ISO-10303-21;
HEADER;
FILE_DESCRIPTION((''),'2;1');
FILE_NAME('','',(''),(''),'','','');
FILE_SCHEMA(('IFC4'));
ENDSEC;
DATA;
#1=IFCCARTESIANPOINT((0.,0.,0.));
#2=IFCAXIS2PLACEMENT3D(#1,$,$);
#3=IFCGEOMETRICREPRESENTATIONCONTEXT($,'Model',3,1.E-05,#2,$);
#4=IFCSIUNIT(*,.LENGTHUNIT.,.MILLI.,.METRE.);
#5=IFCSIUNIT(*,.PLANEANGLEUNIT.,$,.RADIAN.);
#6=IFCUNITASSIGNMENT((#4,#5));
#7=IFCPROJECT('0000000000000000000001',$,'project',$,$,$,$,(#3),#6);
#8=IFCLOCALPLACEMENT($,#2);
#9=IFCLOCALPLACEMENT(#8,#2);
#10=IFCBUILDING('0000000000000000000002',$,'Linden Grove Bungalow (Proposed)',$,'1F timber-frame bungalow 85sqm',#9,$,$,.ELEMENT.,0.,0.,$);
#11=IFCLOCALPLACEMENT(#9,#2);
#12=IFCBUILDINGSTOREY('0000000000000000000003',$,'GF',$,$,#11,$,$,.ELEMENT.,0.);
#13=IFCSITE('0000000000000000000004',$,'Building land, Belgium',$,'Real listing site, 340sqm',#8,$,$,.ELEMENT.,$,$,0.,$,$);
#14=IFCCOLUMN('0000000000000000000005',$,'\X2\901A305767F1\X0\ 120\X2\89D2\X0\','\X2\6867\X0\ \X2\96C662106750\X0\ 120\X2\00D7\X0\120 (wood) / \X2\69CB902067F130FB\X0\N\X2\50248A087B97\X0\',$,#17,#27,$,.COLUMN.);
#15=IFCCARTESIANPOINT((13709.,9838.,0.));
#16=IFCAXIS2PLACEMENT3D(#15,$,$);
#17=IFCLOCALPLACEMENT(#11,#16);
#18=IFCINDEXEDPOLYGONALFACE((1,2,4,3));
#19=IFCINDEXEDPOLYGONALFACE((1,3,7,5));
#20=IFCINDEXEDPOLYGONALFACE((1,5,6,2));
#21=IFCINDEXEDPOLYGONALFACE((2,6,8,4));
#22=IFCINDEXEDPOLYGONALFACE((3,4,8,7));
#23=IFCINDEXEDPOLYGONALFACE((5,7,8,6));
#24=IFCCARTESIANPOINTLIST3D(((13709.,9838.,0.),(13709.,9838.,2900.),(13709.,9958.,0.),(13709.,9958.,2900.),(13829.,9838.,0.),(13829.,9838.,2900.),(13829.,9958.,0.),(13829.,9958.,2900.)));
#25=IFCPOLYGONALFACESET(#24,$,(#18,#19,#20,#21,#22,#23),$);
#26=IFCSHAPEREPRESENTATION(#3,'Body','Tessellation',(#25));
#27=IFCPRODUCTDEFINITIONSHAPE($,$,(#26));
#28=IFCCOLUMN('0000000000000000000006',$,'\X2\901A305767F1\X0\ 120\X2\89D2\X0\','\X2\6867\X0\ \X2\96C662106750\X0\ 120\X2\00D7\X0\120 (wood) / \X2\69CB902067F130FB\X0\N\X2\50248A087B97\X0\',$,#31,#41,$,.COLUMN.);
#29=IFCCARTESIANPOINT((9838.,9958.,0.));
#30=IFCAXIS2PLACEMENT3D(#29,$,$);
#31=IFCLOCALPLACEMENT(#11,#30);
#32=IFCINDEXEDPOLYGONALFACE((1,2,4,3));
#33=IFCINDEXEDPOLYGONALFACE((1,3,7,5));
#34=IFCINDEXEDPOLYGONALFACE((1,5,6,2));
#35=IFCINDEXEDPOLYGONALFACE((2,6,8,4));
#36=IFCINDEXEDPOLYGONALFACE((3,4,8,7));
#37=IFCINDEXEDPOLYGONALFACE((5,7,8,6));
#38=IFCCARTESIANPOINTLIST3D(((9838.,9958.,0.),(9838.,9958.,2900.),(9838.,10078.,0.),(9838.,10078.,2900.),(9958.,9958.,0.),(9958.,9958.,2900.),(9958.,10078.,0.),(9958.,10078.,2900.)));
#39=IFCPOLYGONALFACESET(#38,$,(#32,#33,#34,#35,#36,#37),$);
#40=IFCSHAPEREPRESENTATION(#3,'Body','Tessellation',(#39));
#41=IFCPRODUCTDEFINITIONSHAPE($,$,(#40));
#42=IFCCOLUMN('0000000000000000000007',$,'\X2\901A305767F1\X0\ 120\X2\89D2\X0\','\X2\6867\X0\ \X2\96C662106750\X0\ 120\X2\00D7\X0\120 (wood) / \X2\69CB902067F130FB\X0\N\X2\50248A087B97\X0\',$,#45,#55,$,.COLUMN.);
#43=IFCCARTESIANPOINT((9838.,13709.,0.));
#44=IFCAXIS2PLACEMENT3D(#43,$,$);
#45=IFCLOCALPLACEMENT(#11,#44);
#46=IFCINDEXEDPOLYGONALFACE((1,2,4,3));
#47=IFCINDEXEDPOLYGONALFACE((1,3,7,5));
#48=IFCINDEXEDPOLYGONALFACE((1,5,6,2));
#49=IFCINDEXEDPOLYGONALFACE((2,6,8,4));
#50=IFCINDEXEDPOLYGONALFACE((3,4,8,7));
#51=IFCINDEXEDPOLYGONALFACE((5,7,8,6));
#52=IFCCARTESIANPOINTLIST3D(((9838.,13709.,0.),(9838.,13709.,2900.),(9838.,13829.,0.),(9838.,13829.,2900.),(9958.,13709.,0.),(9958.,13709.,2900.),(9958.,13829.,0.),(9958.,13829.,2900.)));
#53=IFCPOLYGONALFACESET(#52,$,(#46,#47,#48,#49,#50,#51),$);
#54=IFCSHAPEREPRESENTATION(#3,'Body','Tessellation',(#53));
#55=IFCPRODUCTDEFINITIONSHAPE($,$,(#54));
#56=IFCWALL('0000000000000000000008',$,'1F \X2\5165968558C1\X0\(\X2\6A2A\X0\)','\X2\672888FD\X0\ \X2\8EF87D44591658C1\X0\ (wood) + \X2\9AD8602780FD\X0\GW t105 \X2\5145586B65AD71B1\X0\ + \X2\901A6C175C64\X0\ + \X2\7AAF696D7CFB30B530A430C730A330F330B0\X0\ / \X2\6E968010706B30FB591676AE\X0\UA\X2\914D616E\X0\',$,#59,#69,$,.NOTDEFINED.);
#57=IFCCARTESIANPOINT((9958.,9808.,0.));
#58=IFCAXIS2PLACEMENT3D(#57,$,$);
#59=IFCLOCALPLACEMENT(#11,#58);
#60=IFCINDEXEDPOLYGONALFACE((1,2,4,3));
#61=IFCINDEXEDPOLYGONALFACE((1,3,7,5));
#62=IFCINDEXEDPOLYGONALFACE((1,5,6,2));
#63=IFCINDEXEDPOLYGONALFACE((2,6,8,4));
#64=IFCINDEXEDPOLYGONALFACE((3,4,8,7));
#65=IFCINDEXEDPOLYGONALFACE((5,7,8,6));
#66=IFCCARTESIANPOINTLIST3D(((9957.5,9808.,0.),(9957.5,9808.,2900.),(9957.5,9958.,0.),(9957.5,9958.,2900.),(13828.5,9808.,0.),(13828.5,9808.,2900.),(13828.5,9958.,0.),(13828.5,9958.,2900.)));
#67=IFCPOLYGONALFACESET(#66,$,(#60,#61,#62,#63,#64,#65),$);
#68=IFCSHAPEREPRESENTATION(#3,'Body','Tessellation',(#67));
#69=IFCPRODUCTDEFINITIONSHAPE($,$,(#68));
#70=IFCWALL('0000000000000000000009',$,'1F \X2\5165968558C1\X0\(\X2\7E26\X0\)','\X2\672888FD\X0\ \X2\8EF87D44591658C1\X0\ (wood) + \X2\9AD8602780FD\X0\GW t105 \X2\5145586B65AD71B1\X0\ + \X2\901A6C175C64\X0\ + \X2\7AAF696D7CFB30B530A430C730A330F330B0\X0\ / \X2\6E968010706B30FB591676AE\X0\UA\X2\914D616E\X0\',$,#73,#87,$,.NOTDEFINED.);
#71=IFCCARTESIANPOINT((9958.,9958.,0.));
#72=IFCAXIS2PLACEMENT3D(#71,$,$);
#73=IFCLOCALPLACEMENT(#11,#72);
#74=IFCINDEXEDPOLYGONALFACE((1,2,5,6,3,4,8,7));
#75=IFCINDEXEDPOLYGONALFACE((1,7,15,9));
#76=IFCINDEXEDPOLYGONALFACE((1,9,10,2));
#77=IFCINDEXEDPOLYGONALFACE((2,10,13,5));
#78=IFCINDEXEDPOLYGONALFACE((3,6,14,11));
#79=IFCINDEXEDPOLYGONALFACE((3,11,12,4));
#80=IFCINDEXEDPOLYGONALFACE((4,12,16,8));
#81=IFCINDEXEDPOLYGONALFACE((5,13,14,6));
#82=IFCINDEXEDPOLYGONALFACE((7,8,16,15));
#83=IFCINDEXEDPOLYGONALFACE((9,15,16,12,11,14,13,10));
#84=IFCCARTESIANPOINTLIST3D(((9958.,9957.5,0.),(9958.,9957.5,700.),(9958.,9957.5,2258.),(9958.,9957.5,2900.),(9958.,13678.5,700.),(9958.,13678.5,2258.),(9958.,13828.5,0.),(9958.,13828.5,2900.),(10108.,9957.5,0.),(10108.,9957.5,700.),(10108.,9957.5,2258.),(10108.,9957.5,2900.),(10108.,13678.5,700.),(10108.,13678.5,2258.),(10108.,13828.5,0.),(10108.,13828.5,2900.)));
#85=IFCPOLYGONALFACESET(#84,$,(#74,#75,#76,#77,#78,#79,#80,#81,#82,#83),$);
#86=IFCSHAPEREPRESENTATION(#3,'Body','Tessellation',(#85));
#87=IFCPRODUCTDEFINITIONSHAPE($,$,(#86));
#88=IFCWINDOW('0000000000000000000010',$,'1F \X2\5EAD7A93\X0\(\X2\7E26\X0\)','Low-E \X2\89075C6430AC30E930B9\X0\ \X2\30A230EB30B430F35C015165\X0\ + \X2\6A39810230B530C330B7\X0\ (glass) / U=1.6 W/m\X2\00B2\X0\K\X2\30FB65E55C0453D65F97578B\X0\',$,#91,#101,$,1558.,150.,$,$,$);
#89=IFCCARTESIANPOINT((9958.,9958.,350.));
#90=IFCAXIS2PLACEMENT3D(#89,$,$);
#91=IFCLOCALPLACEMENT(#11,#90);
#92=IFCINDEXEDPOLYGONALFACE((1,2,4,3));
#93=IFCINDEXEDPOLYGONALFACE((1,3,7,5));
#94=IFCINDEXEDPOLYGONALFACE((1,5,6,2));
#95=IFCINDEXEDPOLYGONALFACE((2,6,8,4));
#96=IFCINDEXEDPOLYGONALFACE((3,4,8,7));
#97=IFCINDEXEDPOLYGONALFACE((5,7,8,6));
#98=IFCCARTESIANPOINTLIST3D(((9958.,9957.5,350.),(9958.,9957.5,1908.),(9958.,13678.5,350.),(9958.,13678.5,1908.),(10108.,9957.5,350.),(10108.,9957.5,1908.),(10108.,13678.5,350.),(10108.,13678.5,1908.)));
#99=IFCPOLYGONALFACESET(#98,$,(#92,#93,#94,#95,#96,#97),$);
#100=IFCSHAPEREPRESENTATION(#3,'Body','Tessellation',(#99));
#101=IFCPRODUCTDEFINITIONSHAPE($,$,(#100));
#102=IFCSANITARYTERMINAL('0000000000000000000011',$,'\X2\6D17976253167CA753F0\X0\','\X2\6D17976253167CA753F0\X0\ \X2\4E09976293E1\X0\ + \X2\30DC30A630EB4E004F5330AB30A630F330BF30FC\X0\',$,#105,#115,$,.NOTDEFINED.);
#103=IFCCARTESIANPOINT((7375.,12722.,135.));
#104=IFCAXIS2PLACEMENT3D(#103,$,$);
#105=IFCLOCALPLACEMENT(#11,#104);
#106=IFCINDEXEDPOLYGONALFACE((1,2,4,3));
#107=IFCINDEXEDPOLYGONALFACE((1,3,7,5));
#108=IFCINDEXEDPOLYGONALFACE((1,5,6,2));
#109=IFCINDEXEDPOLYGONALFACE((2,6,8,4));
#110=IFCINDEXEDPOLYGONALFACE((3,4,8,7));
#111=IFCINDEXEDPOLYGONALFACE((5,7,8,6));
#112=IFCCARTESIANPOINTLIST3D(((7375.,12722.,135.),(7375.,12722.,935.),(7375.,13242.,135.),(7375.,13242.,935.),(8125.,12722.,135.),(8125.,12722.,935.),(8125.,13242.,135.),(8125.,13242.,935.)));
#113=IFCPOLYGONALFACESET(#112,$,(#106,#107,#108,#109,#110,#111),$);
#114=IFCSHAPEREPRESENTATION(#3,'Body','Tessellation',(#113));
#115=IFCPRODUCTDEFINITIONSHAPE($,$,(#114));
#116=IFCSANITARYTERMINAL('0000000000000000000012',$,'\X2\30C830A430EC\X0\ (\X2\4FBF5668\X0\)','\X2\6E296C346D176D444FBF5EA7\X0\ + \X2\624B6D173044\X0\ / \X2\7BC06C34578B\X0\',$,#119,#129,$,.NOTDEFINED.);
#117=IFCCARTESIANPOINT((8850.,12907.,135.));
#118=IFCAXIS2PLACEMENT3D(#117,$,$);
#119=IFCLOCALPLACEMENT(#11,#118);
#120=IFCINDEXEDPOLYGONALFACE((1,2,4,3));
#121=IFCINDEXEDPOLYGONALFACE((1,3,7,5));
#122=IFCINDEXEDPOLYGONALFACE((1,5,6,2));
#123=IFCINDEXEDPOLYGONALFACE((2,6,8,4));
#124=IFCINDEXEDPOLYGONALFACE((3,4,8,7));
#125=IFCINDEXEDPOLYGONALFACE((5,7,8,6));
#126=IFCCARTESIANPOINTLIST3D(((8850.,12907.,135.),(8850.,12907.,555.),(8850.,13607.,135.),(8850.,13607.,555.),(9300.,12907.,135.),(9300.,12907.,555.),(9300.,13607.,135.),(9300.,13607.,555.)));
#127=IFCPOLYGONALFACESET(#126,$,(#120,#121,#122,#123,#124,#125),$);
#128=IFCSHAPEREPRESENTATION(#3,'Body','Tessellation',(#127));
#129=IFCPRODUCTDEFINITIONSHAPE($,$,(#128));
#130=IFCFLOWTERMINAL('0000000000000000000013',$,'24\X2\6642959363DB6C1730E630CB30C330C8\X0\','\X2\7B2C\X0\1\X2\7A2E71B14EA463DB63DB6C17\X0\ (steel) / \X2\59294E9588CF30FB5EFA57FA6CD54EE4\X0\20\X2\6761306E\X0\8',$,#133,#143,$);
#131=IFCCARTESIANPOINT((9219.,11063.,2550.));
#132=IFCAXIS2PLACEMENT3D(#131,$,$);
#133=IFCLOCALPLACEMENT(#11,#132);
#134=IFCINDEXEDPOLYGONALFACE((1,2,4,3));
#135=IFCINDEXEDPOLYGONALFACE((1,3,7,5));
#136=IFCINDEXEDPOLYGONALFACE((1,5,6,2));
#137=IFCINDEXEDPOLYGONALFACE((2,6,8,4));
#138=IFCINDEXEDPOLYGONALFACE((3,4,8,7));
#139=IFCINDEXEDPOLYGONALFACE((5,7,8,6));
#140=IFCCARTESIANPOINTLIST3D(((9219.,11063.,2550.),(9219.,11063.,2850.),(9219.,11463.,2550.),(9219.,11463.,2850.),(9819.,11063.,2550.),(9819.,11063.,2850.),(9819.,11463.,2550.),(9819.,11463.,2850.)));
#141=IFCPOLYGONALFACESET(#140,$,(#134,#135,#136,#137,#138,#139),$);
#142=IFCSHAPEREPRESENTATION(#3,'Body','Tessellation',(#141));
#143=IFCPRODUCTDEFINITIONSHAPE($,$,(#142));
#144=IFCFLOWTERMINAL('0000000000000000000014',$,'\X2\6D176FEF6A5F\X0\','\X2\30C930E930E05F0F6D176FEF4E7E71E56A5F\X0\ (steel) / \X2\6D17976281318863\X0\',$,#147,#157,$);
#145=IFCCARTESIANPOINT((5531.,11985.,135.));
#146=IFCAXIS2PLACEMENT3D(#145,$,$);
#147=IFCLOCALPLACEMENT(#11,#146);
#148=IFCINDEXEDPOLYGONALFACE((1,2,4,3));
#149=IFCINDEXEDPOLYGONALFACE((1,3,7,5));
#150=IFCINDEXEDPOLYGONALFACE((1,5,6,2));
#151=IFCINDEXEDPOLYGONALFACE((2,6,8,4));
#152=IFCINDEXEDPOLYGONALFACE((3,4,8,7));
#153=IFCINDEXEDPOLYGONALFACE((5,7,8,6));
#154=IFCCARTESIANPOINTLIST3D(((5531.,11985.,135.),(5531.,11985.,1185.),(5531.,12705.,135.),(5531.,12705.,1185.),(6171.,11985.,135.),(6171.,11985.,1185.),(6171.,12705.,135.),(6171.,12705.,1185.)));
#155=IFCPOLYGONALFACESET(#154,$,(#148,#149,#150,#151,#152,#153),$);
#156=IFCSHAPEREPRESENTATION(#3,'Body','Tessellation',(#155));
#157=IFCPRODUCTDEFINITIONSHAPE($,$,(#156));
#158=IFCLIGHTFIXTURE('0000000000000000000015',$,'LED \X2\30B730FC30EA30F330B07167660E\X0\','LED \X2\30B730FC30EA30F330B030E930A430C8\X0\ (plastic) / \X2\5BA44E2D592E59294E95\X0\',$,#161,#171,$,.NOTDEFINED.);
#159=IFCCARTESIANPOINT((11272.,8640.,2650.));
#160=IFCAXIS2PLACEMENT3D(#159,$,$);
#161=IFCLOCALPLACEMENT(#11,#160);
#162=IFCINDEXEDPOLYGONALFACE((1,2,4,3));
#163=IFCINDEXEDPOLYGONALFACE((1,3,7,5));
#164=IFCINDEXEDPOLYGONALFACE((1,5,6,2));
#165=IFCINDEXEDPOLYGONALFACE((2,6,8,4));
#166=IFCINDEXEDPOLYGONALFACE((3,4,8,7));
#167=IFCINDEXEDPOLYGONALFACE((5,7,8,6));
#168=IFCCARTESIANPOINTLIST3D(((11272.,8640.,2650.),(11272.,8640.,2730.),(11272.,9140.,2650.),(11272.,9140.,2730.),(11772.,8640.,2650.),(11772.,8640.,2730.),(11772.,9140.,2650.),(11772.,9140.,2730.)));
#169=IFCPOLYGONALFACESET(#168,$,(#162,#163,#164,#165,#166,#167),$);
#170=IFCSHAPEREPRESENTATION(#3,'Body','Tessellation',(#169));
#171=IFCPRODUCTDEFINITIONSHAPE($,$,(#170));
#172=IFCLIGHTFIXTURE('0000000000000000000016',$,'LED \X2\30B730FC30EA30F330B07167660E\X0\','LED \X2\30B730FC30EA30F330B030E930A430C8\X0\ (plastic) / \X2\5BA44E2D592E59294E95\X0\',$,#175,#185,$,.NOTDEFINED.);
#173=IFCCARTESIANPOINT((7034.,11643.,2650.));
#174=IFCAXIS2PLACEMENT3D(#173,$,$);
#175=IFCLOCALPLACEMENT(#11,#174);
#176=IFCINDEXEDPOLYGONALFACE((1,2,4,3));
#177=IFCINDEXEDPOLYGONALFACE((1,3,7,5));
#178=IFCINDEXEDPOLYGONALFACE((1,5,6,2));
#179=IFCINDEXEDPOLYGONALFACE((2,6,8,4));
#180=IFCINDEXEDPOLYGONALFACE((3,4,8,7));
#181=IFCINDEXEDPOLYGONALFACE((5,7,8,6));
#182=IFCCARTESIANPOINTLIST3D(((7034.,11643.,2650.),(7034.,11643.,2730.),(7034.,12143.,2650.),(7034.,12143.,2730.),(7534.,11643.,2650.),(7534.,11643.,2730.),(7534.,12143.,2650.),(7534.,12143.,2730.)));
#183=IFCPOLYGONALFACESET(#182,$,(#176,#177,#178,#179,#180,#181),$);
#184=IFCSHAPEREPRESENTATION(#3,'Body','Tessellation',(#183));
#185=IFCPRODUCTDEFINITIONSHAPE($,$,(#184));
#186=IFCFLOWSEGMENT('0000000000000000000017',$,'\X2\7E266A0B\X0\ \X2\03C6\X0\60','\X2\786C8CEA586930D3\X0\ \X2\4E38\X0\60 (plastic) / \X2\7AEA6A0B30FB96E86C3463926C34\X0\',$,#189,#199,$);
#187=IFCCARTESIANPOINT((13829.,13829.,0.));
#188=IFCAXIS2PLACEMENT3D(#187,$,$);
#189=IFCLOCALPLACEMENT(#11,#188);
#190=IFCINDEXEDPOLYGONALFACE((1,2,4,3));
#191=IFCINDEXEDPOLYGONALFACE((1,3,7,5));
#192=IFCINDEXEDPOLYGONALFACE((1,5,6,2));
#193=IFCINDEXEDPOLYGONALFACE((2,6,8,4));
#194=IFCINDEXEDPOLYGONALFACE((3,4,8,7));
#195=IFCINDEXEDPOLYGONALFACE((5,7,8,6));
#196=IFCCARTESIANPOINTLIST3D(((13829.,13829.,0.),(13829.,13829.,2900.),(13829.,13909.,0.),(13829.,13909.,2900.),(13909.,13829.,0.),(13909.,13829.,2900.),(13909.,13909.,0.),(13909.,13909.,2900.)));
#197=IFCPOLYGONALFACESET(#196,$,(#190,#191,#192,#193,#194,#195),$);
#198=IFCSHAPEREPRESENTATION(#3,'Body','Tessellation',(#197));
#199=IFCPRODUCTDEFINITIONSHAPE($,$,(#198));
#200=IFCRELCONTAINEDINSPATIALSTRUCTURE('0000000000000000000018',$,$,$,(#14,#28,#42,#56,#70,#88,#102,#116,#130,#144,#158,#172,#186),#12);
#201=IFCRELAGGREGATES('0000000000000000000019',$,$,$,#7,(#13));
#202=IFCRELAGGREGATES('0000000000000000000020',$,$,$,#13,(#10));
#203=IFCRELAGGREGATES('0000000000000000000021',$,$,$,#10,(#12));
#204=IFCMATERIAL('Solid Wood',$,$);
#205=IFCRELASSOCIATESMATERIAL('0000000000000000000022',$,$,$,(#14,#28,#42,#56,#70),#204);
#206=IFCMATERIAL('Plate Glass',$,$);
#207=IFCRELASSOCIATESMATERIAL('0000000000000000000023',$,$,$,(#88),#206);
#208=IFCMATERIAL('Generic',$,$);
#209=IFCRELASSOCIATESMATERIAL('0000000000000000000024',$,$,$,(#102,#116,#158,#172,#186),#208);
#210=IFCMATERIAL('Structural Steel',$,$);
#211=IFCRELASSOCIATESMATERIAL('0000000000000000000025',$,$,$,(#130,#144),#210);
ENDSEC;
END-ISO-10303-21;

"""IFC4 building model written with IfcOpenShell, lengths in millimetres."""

from ifc_helpers import new_model, si_unit, frame, frame_2d, origin, place, context, project, spatial, rectangle, extrude, material, element, fill, save


model = new_model("IFC4")

# Units and contexts
model_context = context("Model", 3, precision=1e-05, world=origin())
ifc_project = project(units=[si_unit("LENGTHUNIT", "METRE", prefix="MILLI"), si_unit("PLANEANGLEUNIT", "RADIAN")], contexts=[model_context])

# Site, building, storey
site_placement = place(None, origin())
site = spatial("IfcSite", under=ifc_project, at=site_placement, Name="Building land, Belgium", ObjectType="Real listing site, 340sqm", CompositionType="ELEMENT", RefElevation=0.0)
building_placement = place(site_placement, origin())
building = spatial("IfcBuilding", under=site, at=building_placement, Name="Linden Grove Bungalow (Proposed)", ObjectType="1F timber-frame bungalow 85sqm", CompositionType="ELEMENT", ElevationOfRefHeight=0.0, ElevationOfTerrain=0.0)
storey_placement = place(building_placement, origin())
storey = spatial("IfcBuildingStorey", under=building, at=storey_placement, Name="GF", CompositionType="ELEMENT", Elevation=0.0)

# Columns
ifc_material_1 = material(Name="Solid Wood")
column_1_placement = place(storey_placement, frame((13709.0, 9838.0, 0.0)))
element("IfcColumn", 1, at=column_1_placement, inside=storey, material=ifc_material_1, Name="通し柱 120角", Description="桧 集成材 120×120 (wood) / 構造柱・N値計算", PredefinedType="COLUMN", context=model_context, shape_type="SweptSolid", body=[
    extrude(rectangle(XDim=120.0, YDim=120.0, at=frame_2d((60.0, 60.0))), frame((13709.0, 9838.0, 0.0)), (0.0, 0.0, 1.0), 2900.0),
])
column_2_placement = place(storey_placement, frame((9838.0, 9958.0, 0.0)))
element("IfcColumn", 2, at=column_2_placement, inside=storey, material=ifc_material_1, Name="通し柱 120角", Description="桧 集成材 120×120 (wood) / 構造柱・N値計算", PredefinedType="COLUMN", context=model_context, shape_type="SweptSolid", body=[
    extrude(rectangle(XDim=120.0, YDim=120.0, at=frame_2d((60.0, 60.0))), frame((9838.0, 9958.0, 0.0)), (0.0, 0.0, 1.0), 2900.0),
])
column_3_placement = place(storey_placement, frame((9838.0, 13709.0, 0.0)))
element("IfcColumn", 3, at=column_3_placement, inside=storey, material=ifc_material_1, Name="通し柱 120角", Description="桧 集成材 120×120 (wood) / 構造柱・N値計算", PredefinedType="COLUMN", context=model_context, shape_type="SweptSolid", body=[
    extrude(rectangle(XDim=120.0, YDim=120.0, at=frame_2d((60.0, 60.0))), frame((9838.0, 13709.0, 0.0)), (0.0, 0.0, 1.0), 2900.0),
])

# Wall
wall_1_placement = place(storey_placement, frame((9958.0, 9808.0, 0.0)))
element("IfcWall", 4, at=wall_1_placement, inside=storey, material=ifc_material_1, Name="1F 入隅壁(横)", Description="木製 軸組外壁 (wood) + 高性能GW t105 充填断熱 + 通気層 + 窯業系サイディング / 準耐火・外皮UA配慮", PredefinedType="NOTDEFINED", context=model_context, shape_type="SweptSolid", body=[
    extrude(rectangle(XDim=3871.0, YDim=150.0, at=frame_2d((1935.0, 75.0))), frame((9958.0, 9808.0, 0.0)), (0.0, 0.0, 1.0), 2900.0),
])

# Wall, opening, window
wall_2_placement = place(storey_placement, frame((9958.0, 9958.0, 0.0)))
wall_2 = element("IfcWall", 5, at=wall_2_placement, inside=storey, material=ifc_material_1, Name="1F 入隅壁(縦)", Description="木製 軸組外壁 (wood) + 高性能GW t105 充填断熱 + 通気層 + 窯業系サイディング / 準耐火・外皮UA配慮", PredefinedType="NOTDEFINED", context=model_context, shape_type="SweptSolid", body=[
    extrude(rectangle(XDim=150.0, YDim=3871.0, at=frame_2d((75.0, 1935.0))), frame((9958.0, 9958.0, 0.0)), (0.0, 0.0, 1.0), 2900.0),
])
opening_placement = place(storey_placement, frame((9958.0, 9958.0, 350.0)))
opening = element("IfcOpeningElement", 6, at=opening_placement, cuts=wall_2, PredefinedType="NOTDEFINED", context=model_context, shape_type="SweptSolid", body=[
    extrude(rectangle(XDim=150.0, YDim=3721.0, at=frame_2d((75.0, 1860.0))), frame((9958.0, 9958.0, 350.0)), (0.0, 0.0, 1.0), 1558.0),
])
ifc_material_2 = material(Name="Plate Glass")
window_placement = place(storey_placement, frame((9958.0, 9958.0, 350.0)))
window = element("IfcWindow", 7, at=window_placement, inside=storey, material=ifc_material_2, Name="1F 庭窓(縦)", Description="Low-E 複層ガラス アルゴン封入 + 樹脂サッシ (glass) / U=1.6 W/m²K・日射取得型", OverallHeight=1558.0, OverallWidth=150.0, context=model_context, shape_type="SweptSolid", body=[
    extrude(rectangle(XDim=150.0, YDim=3721.0, at=frame_2d((75.0, 1860.0))), frame((9958.0, 9958.0, 350.0)), (0.0, 0.0, 1.0), 1558.0),
])
fill(opening, window)

# Sanitary terminals
ifc_material_3 = material(Name="Generic")
sanitary_terminal_1_placement = place(storey_placement, frame((7375.0, 12722.0, 135.0)))
element("IfcSanitaryTerminal", 8, at=sanitary_terminal_1_placement, inside=storey, material=ifc_material_3, Name="洗面化粧台", Description="洗面化粧台 三面鏡 + ボウル一体カウンター", PredefinedType="NOTDEFINED", context=model_context, shape_type="SweptSolid", body=[
    extrude(rectangle(XDim=750.0, YDim=520.0, at=frame_2d((375.0, 260.0))), frame((7375.0, 12722.0, 135.0)), (0.0, 0.0, 1.0), 800.0),
])
sanitary_terminal_2_placement = place(storey_placement, frame((8850.0, 12907.0, 135.0)))
element("IfcSanitaryTerminal", 9, at=sanitary_terminal_2_placement, inside=storey, material=ifc_material_3, Name="トイレ (便器)", Description="温水洗浄便座 + 手洗い / 節水型", PredefinedType="NOTDEFINED", context=model_context, shape_type="SweptSolid", body=[
    extrude(rectangle(XDim=450.0, YDim=700.0, at=frame_2d((225.0, 350.0))), frame((8850.0, 12907.0, 135.0)), (0.0, 0.0, 1.0), 420.0),
])

# Flow terminals
ifc_material_4 = material(Name="Structural Steel")
flow_terminal_1_placement = place(storey_placement, frame((9219.0, 11063.0, 2550.0)))
element("IfcFlowTerminal", 10, at=flow_terminal_1_placement, inside=storey, material=ifc_material_4, Name="24時間換気ユニット", Description="第1種熱交換換気 (steel) / 天井裏・建基法令20条の8", context=model_context, shape_type="SweptSolid", body=[
    extrude(rectangle(XDim=600.0, YDim=400.0, at=frame_2d((300.0, 200.0))), frame((9219.0, 11063.0, 2550.0)), (0.0, 0.0, 1.0), 300.0),
])
flow_terminal_2_placement = place(storey_placement, frame((5531.0, 11985.0, 135.0)))
element("IfcFlowTerminal", 11, at=flow_terminal_2_placement, inside=storey, material=ifc_material_4, Name="洗濯機", Description="ドラム式洗濯乾燥機 (steel) / 洗面脱衣", context=model_context, shape_type="SweptSolid", body=[
    extrude(rectangle(XDim=640.0, YDim=720.0, at=frame_2d((320.0, 360.0))), frame((5531.0, 11985.0, 135.0)), (0.0, 0.0, 1.0), 1050.0),
])

# Light fixtures
light_fixture_1_placement = place(storey_placement, frame((11272.0, 8640.0, 2650.0)))
element("IfcLightFixture", 12, at=light_fixture_1_placement, inside=storey, material=ifc_material_3, Name="LED シーリング照明", Description="LED シーリングライト (plastic) / 室中央天井", PredefinedType="NOTDEFINED", context=model_context, shape_type="SweptSolid", body=[
    extrude(rectangle(XDim=500.0, YDim=500.0, at=frame_2d((250.0, 250.0))), frame((11272.0, 8640.0, 2650.0)), (0.0, 0.0, 1.0), 80.0),
])
light_fixture_2_placement = place(storey_placement, frame((7034.0, 11643.0, 2650.0)))
element("IfcLightFixture", 13, at=light_fixture_2_placement, inside=storey, material=ifc_material_3, Name="LED シーリング照明", Description="LED シーリングライト (plastic) / 室中央天井", PredefinedType="NOTDEFINED", context=model_context, shape_type="SweptSolid", body=[
    extrude(rectangle(XDim=500.0, YDim=500.0, at=frame_2d((250.0, 250.0))), frame((7034.0, 11643.0, 2650.0)), (0.0, 0.0, 1.0), 80.0),
])

# Flow segment
flow_segment_placement = place(storey_placement, frame((13829.0, 13829.0, 0.0)))
element("IfcFlowSegment", 14, at=flow_segment_placement, inside=storey, material=ifc_material_3, Name="縦樋 φ60", Description="硬質塩ビ 丸60 (plastic) / 竪樋・雨水排水", context=model_context, shape_type="SweptSolid", body=[
    extrude(rectangle(XDim=80.0, YDim=80.0, at=frame_2d((40.0, 40.0))), frame((13829.0, 13829.0, 0.0)), (0.0, 0.0, 1.0), 2900.0),
])

save(model, "model.ifc")
